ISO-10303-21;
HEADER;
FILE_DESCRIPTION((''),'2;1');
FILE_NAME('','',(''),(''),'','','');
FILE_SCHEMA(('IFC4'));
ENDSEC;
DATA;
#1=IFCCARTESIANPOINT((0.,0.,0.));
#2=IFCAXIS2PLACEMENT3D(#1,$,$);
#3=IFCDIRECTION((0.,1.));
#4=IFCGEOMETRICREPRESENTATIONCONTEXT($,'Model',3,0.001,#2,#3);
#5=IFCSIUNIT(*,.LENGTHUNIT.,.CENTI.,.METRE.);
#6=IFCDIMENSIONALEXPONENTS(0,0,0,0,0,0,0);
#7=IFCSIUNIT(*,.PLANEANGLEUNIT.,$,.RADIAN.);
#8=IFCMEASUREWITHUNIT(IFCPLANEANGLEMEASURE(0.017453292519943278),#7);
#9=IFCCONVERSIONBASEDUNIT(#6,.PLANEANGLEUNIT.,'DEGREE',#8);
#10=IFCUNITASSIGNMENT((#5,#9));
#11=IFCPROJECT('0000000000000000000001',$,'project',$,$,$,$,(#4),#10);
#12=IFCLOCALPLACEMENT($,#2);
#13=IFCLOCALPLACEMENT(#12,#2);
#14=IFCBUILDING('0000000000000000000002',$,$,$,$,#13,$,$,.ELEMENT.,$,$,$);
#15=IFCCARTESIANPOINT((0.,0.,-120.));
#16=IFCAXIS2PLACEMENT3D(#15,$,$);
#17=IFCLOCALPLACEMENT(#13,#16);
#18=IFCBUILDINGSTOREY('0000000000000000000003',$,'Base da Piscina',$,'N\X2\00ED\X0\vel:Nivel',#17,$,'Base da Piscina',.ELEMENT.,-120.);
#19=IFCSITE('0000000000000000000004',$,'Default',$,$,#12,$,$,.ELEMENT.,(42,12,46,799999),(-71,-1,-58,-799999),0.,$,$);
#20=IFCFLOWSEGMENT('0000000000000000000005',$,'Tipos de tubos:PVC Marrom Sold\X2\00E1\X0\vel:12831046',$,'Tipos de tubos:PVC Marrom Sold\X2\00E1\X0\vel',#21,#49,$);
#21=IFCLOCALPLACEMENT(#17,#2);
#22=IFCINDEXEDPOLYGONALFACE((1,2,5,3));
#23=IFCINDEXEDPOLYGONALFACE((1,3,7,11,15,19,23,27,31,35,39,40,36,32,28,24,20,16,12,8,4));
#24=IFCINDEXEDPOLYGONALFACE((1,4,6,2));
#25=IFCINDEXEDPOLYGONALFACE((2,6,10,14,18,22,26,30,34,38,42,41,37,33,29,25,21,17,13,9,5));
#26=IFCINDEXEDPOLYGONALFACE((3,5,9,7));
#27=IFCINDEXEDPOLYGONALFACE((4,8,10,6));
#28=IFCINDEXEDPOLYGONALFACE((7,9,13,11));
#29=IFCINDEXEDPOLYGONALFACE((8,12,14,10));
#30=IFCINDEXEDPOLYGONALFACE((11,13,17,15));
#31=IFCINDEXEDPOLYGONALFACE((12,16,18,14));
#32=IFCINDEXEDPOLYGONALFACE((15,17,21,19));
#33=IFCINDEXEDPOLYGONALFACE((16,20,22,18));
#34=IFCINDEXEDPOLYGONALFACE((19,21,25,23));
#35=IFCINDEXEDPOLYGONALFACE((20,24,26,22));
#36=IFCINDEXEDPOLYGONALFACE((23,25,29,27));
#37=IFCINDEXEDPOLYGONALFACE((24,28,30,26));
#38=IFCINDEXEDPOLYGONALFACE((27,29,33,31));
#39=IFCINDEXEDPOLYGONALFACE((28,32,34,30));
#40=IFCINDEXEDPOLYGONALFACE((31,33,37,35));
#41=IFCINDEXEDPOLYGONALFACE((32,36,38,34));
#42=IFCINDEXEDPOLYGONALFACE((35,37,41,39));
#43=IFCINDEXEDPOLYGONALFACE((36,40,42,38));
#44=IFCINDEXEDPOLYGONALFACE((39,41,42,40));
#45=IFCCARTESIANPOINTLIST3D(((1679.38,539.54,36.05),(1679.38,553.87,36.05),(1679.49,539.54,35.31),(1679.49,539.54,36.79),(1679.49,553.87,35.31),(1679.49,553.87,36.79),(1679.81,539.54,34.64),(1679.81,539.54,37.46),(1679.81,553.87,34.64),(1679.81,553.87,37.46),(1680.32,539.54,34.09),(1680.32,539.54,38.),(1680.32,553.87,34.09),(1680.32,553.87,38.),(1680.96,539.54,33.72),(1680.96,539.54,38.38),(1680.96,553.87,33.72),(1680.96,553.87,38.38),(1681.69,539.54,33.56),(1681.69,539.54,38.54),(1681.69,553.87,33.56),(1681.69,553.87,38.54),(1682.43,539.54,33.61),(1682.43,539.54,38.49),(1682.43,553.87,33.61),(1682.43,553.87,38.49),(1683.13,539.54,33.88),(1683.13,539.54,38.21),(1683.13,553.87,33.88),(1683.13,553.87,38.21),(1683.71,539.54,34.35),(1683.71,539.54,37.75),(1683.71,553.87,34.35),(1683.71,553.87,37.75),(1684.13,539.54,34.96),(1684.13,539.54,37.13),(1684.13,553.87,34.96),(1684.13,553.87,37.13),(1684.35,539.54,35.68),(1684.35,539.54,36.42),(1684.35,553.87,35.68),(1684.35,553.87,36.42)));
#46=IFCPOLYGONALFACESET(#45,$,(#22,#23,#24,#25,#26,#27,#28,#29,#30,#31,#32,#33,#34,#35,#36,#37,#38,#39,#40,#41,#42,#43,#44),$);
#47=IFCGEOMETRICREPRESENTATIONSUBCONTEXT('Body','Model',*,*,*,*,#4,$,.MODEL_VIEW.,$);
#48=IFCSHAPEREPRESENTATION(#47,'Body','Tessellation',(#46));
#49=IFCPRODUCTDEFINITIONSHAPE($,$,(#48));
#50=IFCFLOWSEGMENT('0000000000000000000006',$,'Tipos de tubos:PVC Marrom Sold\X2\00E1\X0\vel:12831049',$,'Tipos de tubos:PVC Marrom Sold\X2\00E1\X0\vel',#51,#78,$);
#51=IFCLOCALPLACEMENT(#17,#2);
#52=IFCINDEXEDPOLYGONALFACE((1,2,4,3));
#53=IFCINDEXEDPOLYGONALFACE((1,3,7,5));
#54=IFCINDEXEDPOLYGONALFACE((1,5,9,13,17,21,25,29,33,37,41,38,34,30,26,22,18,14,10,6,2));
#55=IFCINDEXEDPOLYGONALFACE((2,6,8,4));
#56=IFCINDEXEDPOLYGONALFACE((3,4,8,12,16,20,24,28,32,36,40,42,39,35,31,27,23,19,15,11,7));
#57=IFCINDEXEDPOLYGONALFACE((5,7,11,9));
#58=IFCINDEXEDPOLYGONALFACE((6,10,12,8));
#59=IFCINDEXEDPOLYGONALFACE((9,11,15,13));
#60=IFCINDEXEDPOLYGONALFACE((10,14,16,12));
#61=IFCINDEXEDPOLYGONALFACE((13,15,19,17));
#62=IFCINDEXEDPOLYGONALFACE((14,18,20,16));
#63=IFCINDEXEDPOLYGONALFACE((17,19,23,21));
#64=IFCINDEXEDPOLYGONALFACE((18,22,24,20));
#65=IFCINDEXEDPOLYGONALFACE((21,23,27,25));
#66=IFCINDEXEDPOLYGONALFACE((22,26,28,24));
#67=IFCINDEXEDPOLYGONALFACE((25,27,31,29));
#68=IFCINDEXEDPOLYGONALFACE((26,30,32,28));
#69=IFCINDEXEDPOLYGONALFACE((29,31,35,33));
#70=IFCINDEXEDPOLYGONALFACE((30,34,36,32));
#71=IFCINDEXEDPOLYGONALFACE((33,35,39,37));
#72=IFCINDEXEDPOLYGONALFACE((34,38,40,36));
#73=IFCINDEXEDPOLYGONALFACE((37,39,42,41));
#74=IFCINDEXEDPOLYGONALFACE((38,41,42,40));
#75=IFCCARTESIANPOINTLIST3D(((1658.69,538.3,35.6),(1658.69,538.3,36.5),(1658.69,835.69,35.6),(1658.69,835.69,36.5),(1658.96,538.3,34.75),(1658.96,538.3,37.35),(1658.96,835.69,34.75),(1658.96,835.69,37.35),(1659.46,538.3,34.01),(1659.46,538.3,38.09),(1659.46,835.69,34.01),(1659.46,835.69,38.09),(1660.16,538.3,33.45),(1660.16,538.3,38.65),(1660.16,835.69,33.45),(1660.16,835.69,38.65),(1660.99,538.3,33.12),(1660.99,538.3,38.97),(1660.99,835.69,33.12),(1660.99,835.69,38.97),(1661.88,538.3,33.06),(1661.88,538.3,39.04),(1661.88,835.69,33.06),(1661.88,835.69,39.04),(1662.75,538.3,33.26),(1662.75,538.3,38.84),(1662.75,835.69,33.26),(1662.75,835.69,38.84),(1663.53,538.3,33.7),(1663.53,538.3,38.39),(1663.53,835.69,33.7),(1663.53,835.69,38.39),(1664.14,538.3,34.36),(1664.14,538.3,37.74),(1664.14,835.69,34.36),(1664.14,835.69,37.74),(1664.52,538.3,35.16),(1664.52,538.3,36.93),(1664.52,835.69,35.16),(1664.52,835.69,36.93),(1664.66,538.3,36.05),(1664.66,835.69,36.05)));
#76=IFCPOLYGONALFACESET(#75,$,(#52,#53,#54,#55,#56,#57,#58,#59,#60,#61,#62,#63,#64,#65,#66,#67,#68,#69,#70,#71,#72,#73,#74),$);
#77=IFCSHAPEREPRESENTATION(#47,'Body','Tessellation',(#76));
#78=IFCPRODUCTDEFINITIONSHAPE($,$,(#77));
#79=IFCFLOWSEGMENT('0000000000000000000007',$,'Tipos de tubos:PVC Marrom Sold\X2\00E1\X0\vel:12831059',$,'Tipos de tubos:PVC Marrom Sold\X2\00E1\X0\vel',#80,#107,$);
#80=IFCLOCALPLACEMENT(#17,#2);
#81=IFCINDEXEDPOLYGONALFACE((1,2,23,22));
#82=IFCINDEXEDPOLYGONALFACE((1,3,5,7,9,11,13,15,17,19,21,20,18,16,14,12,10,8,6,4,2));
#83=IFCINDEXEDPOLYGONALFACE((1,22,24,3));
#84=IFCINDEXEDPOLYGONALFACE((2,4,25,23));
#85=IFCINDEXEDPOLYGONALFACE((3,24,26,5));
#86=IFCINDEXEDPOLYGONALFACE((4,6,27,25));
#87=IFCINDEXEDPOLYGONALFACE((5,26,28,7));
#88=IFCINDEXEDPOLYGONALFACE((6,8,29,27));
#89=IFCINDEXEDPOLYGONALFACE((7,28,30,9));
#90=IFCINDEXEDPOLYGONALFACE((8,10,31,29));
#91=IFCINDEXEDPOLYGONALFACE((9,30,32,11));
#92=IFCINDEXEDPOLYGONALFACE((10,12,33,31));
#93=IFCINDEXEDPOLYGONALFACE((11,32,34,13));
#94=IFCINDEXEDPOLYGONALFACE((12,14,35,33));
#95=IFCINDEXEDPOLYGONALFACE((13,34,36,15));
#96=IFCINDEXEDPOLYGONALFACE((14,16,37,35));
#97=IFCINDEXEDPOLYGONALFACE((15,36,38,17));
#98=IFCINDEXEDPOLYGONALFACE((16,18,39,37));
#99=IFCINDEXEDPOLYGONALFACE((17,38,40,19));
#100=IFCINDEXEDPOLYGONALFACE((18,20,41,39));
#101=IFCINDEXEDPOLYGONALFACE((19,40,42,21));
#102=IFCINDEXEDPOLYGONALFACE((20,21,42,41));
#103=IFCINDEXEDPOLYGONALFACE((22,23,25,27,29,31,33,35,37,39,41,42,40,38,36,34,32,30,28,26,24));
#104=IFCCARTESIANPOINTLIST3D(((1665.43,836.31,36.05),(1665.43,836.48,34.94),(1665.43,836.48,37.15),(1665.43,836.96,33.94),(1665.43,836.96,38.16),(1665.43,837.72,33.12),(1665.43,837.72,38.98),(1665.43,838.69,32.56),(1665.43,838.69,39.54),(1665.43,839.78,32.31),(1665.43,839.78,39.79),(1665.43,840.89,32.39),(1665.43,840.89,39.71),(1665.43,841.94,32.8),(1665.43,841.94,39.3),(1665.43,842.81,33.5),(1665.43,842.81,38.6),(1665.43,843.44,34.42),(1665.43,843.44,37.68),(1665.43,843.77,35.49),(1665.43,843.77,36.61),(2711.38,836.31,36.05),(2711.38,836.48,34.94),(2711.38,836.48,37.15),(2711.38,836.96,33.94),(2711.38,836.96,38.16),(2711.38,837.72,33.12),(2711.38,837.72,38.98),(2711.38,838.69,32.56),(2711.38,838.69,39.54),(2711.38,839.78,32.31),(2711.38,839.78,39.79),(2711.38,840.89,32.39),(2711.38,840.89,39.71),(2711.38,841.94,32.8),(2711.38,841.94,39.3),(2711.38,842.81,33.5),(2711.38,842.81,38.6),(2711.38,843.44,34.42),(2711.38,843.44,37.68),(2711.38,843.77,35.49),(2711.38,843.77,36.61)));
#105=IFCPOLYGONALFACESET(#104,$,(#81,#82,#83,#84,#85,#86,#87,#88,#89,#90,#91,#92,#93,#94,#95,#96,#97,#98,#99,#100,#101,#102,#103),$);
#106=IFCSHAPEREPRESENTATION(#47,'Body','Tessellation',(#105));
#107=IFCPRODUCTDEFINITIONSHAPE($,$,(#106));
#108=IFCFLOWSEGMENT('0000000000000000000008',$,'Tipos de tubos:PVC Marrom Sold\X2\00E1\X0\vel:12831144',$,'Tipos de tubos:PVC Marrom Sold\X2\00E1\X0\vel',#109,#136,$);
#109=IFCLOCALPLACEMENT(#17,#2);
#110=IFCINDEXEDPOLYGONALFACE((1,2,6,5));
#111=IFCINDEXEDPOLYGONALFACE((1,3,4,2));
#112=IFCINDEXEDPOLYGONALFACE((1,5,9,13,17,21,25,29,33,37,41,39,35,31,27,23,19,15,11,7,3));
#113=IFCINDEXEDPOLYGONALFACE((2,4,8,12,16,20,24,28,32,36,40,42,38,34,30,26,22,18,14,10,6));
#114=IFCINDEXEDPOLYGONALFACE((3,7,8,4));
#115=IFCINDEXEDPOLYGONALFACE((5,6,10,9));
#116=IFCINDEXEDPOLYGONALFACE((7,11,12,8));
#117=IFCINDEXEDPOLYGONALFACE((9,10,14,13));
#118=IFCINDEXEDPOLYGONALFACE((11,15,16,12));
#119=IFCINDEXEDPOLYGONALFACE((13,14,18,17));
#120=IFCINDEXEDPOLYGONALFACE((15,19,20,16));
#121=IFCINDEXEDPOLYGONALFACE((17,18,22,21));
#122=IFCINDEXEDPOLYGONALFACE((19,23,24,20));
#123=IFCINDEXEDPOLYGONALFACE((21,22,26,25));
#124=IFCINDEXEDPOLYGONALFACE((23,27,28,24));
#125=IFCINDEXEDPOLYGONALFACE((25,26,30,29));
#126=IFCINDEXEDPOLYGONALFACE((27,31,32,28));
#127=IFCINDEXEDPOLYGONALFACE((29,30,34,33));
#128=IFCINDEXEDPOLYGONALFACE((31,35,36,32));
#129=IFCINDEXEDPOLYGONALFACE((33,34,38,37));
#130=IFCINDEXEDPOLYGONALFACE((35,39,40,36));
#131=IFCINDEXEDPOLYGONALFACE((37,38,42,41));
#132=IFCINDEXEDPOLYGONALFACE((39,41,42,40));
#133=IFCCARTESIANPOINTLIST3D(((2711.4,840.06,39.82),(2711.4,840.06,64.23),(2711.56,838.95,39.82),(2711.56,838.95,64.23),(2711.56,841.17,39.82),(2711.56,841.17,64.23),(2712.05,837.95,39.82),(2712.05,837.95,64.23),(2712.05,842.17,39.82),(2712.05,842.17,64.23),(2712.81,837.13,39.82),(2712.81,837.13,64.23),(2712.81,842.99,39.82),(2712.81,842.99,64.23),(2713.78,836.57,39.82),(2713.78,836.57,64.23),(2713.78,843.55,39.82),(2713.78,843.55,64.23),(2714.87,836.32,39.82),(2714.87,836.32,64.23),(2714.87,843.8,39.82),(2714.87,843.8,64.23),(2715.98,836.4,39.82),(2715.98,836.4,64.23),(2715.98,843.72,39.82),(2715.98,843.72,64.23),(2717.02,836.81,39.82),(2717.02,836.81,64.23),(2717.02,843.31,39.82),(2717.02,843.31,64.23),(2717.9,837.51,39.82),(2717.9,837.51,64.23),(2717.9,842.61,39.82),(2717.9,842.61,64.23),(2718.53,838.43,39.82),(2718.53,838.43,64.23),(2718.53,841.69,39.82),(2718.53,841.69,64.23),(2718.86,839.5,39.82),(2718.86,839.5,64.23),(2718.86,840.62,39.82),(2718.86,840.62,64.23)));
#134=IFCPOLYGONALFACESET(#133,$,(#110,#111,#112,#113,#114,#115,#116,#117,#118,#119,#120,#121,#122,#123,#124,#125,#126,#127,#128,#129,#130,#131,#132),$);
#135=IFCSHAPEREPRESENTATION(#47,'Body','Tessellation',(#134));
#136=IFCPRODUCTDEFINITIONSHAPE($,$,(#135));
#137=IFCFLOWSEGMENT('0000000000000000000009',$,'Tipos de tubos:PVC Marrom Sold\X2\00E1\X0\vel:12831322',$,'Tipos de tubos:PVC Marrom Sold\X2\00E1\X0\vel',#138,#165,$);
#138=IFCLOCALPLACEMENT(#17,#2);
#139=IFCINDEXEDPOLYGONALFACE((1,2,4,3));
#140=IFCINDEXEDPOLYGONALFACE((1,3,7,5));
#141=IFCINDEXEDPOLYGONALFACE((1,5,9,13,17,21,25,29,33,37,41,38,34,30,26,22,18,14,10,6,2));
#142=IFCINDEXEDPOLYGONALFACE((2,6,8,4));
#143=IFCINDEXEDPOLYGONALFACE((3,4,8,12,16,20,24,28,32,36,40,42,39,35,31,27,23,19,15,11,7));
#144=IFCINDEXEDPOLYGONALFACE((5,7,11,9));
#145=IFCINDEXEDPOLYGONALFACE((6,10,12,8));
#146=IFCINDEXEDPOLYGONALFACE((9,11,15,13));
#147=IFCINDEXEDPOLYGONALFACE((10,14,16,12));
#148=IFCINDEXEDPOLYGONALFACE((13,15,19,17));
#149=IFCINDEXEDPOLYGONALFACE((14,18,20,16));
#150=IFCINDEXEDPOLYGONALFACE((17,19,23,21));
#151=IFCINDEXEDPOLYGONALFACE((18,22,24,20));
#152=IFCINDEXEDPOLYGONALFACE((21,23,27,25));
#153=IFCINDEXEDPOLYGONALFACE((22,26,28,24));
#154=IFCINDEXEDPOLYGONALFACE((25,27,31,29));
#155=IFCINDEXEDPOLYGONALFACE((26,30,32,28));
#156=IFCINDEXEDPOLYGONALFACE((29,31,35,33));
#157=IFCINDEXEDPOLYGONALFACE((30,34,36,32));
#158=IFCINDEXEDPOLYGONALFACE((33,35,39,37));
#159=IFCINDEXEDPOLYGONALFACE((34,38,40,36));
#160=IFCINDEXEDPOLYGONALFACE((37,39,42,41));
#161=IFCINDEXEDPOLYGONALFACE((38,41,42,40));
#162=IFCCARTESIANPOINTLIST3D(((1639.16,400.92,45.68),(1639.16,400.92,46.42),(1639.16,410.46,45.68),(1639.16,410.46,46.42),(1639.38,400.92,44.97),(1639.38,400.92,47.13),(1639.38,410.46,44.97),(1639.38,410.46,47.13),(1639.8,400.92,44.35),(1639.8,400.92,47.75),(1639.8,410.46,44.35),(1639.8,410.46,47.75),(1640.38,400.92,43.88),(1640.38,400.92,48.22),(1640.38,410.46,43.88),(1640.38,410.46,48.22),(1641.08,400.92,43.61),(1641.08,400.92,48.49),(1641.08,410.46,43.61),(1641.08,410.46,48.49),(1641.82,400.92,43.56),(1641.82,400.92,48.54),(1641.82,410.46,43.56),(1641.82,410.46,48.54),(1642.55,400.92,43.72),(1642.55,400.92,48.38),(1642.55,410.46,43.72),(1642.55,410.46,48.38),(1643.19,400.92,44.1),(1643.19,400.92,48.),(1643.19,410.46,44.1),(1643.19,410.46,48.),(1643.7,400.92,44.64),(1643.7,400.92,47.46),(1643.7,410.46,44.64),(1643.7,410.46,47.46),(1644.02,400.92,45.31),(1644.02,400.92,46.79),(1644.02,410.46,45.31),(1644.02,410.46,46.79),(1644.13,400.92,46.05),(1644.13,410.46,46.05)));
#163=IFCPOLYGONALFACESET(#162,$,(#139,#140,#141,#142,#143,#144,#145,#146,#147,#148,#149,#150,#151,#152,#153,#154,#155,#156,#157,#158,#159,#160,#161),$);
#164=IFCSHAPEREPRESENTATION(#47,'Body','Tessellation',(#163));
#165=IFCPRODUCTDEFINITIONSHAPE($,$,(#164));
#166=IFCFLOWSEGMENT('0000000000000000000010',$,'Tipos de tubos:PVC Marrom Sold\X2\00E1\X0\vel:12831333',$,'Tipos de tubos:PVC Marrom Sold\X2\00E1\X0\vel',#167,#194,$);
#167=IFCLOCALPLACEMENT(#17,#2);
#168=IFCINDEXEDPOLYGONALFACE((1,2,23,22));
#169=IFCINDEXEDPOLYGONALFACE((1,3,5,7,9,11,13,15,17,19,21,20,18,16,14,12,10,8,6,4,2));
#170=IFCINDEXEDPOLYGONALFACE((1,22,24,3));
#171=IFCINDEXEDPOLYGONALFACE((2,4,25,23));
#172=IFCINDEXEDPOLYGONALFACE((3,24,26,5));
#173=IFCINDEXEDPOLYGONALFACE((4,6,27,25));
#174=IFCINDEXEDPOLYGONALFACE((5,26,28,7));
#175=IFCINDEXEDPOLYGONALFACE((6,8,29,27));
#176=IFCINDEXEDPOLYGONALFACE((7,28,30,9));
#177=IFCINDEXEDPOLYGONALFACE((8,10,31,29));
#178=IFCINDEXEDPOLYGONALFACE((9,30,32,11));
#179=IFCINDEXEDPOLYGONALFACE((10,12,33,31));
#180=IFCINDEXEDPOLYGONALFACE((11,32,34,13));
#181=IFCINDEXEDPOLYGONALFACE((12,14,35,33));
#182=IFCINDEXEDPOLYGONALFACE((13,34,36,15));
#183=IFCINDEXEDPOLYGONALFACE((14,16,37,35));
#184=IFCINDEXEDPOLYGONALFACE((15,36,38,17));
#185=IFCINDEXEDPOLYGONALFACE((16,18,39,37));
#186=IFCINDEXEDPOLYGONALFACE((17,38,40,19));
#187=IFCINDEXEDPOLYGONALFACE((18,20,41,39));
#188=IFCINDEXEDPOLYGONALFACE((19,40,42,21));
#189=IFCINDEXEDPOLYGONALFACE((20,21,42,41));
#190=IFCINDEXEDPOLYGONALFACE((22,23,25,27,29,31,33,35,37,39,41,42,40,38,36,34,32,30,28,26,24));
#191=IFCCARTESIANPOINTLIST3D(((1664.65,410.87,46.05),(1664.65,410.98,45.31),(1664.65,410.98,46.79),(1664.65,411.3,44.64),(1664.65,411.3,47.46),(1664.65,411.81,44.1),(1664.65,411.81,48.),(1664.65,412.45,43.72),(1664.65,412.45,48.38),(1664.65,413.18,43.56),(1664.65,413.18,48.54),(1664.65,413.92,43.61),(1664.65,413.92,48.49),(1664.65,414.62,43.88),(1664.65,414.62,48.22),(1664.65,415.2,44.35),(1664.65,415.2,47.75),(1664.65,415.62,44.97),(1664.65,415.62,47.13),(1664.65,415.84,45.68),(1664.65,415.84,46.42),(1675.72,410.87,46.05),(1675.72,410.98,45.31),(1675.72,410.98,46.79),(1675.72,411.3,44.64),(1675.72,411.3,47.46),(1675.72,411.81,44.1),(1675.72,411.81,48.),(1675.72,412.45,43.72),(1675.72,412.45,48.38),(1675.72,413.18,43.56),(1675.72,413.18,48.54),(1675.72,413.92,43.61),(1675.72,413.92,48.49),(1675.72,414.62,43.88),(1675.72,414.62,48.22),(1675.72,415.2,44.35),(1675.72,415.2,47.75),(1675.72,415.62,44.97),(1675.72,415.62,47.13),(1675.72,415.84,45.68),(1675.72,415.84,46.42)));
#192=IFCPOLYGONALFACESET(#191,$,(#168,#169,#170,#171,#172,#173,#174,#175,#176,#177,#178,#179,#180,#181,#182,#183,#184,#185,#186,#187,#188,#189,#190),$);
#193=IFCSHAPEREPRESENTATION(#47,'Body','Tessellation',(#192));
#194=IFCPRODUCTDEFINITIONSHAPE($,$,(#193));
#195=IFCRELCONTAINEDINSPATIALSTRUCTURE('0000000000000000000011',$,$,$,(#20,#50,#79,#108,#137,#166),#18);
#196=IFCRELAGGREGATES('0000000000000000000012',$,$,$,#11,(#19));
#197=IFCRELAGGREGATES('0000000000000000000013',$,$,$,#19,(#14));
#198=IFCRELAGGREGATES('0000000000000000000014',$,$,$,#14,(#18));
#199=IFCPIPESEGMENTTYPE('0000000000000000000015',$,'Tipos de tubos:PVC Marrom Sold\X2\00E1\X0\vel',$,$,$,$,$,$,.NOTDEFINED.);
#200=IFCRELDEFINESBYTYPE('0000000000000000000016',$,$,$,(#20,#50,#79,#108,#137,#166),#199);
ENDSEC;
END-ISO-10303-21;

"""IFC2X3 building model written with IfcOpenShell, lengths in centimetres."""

from ifc_helpers import new_model, entity, si_unit, converted_unit, direction, frame, frame_2d, origin, origin_2d_with_axis, place, context, subcontext, project, spatial, circle, extrude, type_object, element, save


model = new_model("IFC2X3")

# Units and contexts
model_context = context("Model", 3, precision=0.001, world=origin(), true_north=direction((0.0, 1.0)))
body_context = subcontext(model_context, "Body", "Model", "MODEL_VIEW")
ifc_project = project(units=[si_unit("LENGTHUNIT", "METRE", prefix="CENTI"), converted_unit("PLANEANGLEUNIT", "DEGREE", entity("IfcPlaneAngleMeasure", 0.017453292519943278), si_unit("PLANEANGLEUNIT", "RADIAN"), dimensions=[0, 0, 0, 0, 0, 0, 0])], contexts=[model_context])

# Site, building, storey
site_placement = place(None, origin())
site = spatial("IfcSite", under=ifc_project, at=site_placement, Name="Default", CompositionType="ELEMENT", RefLatitude=(42, 12, 46, 799999), RefLongitude=(-71, -1, -58, -799999), RefElevation=0.0)
building_placement = place(site_placement, origin())
building = spatial("IfcBuilding", under=site, at=building_placement, CompositionType="ELEMENT")
storey_placement = place(building_placement, frame((0.0, 0.0, -120.0)))
storey = spatial("IfcBuildingStorey", under=building, at=storey_placement, Name="Base da Piscina", ObjectType="Nível:Nivel", LongName="Base da Piscina", CompositionType="ELEMENT", Elevation=-120.0)

# Flow segments
pipe_segment_type = type_object("IfcPipeSegmentType", Name="Tipos de tubos:PVC Marrom Soldável", PredefinedType="NOTDEFINED")
flow_segment_1_placement = place(storey_placement, origin())
element("IfcFlowSegment", 1, at=flow_segment_1_placement, inside=storey, type_object=pipe_segment_type, Name="Tipos de tubos:PVC Marrom Soldável:12831046", ObjectType="Tipos de tubos:PVC Marrom Soldável", context=body_context, shape_type="SweptSolid", body=[
    extrude(circle(Radius=2.5, at=origin_2d_with_axis()), frame((1681.88, 539.54, 36.05), z_axis=(0.0, 1.0, 0.0), x_axis=(-1.0, 0.0, 0.0)), (0.0, 0.0, 1.0), 14.33),
])
flow_segment_2_placement = place(storey_placement, origin())
element("IfcFlowSegment", 2, at=flow_segment_2_placement, inside=storey, type_object=pipe_segment_type, Name="Tipos de tubos:PVC Marrom Soldável:12831049", ObjectType="Tipos de tubos:PVC Marrom Soldável", context=body_context, shape_type="SweptSolid", body=[
    extrude(circle(Radius=3.0, at=origin_2d_with_axis()), frame((1661.66, 538.3, 36.05), z_axis=(0.0, 1.0, 0.0), x_axis=(1.0, 0.0, 0.0)), (0.0, 0.0, 1.0), 297.39),
])
flow_segment_3_placement = place(storey_placement, origin())
element("IfcFlowSegment", 3, at=flow_segment_3_placement, inside=storey, type_object=pipe_segment_type, Name="Tipos de tubos:PVC Marrom Soldável:12831059", ObjectType="Tipos de tubos:PVC Marrom Soldável", context=body_context, shape_type="SweptSolid", body=[
    extrude(circle(Radius=3.75, at=frame_2d((0.0, 0.0), x_axis=(1.0, 0.0))), frame((1665.43, 840.06, 36.05), z_axis=(1.0, 0.0, 0.0), x_axis=(0.0, -1.0, 0.0)), (0.0, 0.0, 1.0), 1045.95),
])
flow_segment_4_placement = place(storey_placement, origin())
element("IfcFlowSegment", 4, at=flow_segment_4_placement, inside=storey, type_object=pipe_segment_type, Name="Tipos de tubos:PVC Marrom Soldável:12831144", ObjectType="Tipos de tubos:PVC Marrom Soldável", context=body_context, shape_type="SweptSolid", body=[
    extrude(circle(Radius=3.75, at=origin_2d_with_axis()), frame((2715.15, 840.06, 39.82), z_axis=(0.0, 0.0, 1.0), x_axis=(-1.0, 0.0, 0.0)), (0.0, 0.0, 1.0), 24.41),
])
flow_segment_5_placement = place(storey_placement, origin())
element("IfcFlowSegment", 5, at=flow_segment_5_placement, inside=storey, type_object=pipe_segment_type, Name="Tipos de tubos:PVC Marrom Soldável:12831322", ObjectType="Tipos de tubos:PVC Marrom Soldável", context=body_context, shape_type="SweptSolid", body=[
    extrude(circle(Radius=2.5, at=origin_2d_with_axis()), frame((1641.63, 400.92, 46.05), z_axis=(0.0, 1.0, 0.0), x_axis=(1.0, 0.0, 0.0)), (0.0, 0.0, 1.0), 9.53),
])
flow_segment_6_placement = place(storey_placement, origin())
element("IfcFlowSegment", 6, at=flow_segment_6_placement, inside=storey, type_object=pipe_segment_type, Name="Tipos de tubos:PVC Marrom Soldável:12831333", ObjectType="Tipos de tubos:PVC Marrom Soldável", context=body_context, shape_type="SweptSolid", body=[
    extrude(circle(Radius=2.5, at=origin_2d_with_axis()), frame((1664.65, 413.37, 46.05), z_axis=(1.0, 0.0, 0.0), x_axis=(0.0, -1.0, 0.0)), (0.0, 0.0, 1.0), 11.07),
])

save(model, "model.ifc")
